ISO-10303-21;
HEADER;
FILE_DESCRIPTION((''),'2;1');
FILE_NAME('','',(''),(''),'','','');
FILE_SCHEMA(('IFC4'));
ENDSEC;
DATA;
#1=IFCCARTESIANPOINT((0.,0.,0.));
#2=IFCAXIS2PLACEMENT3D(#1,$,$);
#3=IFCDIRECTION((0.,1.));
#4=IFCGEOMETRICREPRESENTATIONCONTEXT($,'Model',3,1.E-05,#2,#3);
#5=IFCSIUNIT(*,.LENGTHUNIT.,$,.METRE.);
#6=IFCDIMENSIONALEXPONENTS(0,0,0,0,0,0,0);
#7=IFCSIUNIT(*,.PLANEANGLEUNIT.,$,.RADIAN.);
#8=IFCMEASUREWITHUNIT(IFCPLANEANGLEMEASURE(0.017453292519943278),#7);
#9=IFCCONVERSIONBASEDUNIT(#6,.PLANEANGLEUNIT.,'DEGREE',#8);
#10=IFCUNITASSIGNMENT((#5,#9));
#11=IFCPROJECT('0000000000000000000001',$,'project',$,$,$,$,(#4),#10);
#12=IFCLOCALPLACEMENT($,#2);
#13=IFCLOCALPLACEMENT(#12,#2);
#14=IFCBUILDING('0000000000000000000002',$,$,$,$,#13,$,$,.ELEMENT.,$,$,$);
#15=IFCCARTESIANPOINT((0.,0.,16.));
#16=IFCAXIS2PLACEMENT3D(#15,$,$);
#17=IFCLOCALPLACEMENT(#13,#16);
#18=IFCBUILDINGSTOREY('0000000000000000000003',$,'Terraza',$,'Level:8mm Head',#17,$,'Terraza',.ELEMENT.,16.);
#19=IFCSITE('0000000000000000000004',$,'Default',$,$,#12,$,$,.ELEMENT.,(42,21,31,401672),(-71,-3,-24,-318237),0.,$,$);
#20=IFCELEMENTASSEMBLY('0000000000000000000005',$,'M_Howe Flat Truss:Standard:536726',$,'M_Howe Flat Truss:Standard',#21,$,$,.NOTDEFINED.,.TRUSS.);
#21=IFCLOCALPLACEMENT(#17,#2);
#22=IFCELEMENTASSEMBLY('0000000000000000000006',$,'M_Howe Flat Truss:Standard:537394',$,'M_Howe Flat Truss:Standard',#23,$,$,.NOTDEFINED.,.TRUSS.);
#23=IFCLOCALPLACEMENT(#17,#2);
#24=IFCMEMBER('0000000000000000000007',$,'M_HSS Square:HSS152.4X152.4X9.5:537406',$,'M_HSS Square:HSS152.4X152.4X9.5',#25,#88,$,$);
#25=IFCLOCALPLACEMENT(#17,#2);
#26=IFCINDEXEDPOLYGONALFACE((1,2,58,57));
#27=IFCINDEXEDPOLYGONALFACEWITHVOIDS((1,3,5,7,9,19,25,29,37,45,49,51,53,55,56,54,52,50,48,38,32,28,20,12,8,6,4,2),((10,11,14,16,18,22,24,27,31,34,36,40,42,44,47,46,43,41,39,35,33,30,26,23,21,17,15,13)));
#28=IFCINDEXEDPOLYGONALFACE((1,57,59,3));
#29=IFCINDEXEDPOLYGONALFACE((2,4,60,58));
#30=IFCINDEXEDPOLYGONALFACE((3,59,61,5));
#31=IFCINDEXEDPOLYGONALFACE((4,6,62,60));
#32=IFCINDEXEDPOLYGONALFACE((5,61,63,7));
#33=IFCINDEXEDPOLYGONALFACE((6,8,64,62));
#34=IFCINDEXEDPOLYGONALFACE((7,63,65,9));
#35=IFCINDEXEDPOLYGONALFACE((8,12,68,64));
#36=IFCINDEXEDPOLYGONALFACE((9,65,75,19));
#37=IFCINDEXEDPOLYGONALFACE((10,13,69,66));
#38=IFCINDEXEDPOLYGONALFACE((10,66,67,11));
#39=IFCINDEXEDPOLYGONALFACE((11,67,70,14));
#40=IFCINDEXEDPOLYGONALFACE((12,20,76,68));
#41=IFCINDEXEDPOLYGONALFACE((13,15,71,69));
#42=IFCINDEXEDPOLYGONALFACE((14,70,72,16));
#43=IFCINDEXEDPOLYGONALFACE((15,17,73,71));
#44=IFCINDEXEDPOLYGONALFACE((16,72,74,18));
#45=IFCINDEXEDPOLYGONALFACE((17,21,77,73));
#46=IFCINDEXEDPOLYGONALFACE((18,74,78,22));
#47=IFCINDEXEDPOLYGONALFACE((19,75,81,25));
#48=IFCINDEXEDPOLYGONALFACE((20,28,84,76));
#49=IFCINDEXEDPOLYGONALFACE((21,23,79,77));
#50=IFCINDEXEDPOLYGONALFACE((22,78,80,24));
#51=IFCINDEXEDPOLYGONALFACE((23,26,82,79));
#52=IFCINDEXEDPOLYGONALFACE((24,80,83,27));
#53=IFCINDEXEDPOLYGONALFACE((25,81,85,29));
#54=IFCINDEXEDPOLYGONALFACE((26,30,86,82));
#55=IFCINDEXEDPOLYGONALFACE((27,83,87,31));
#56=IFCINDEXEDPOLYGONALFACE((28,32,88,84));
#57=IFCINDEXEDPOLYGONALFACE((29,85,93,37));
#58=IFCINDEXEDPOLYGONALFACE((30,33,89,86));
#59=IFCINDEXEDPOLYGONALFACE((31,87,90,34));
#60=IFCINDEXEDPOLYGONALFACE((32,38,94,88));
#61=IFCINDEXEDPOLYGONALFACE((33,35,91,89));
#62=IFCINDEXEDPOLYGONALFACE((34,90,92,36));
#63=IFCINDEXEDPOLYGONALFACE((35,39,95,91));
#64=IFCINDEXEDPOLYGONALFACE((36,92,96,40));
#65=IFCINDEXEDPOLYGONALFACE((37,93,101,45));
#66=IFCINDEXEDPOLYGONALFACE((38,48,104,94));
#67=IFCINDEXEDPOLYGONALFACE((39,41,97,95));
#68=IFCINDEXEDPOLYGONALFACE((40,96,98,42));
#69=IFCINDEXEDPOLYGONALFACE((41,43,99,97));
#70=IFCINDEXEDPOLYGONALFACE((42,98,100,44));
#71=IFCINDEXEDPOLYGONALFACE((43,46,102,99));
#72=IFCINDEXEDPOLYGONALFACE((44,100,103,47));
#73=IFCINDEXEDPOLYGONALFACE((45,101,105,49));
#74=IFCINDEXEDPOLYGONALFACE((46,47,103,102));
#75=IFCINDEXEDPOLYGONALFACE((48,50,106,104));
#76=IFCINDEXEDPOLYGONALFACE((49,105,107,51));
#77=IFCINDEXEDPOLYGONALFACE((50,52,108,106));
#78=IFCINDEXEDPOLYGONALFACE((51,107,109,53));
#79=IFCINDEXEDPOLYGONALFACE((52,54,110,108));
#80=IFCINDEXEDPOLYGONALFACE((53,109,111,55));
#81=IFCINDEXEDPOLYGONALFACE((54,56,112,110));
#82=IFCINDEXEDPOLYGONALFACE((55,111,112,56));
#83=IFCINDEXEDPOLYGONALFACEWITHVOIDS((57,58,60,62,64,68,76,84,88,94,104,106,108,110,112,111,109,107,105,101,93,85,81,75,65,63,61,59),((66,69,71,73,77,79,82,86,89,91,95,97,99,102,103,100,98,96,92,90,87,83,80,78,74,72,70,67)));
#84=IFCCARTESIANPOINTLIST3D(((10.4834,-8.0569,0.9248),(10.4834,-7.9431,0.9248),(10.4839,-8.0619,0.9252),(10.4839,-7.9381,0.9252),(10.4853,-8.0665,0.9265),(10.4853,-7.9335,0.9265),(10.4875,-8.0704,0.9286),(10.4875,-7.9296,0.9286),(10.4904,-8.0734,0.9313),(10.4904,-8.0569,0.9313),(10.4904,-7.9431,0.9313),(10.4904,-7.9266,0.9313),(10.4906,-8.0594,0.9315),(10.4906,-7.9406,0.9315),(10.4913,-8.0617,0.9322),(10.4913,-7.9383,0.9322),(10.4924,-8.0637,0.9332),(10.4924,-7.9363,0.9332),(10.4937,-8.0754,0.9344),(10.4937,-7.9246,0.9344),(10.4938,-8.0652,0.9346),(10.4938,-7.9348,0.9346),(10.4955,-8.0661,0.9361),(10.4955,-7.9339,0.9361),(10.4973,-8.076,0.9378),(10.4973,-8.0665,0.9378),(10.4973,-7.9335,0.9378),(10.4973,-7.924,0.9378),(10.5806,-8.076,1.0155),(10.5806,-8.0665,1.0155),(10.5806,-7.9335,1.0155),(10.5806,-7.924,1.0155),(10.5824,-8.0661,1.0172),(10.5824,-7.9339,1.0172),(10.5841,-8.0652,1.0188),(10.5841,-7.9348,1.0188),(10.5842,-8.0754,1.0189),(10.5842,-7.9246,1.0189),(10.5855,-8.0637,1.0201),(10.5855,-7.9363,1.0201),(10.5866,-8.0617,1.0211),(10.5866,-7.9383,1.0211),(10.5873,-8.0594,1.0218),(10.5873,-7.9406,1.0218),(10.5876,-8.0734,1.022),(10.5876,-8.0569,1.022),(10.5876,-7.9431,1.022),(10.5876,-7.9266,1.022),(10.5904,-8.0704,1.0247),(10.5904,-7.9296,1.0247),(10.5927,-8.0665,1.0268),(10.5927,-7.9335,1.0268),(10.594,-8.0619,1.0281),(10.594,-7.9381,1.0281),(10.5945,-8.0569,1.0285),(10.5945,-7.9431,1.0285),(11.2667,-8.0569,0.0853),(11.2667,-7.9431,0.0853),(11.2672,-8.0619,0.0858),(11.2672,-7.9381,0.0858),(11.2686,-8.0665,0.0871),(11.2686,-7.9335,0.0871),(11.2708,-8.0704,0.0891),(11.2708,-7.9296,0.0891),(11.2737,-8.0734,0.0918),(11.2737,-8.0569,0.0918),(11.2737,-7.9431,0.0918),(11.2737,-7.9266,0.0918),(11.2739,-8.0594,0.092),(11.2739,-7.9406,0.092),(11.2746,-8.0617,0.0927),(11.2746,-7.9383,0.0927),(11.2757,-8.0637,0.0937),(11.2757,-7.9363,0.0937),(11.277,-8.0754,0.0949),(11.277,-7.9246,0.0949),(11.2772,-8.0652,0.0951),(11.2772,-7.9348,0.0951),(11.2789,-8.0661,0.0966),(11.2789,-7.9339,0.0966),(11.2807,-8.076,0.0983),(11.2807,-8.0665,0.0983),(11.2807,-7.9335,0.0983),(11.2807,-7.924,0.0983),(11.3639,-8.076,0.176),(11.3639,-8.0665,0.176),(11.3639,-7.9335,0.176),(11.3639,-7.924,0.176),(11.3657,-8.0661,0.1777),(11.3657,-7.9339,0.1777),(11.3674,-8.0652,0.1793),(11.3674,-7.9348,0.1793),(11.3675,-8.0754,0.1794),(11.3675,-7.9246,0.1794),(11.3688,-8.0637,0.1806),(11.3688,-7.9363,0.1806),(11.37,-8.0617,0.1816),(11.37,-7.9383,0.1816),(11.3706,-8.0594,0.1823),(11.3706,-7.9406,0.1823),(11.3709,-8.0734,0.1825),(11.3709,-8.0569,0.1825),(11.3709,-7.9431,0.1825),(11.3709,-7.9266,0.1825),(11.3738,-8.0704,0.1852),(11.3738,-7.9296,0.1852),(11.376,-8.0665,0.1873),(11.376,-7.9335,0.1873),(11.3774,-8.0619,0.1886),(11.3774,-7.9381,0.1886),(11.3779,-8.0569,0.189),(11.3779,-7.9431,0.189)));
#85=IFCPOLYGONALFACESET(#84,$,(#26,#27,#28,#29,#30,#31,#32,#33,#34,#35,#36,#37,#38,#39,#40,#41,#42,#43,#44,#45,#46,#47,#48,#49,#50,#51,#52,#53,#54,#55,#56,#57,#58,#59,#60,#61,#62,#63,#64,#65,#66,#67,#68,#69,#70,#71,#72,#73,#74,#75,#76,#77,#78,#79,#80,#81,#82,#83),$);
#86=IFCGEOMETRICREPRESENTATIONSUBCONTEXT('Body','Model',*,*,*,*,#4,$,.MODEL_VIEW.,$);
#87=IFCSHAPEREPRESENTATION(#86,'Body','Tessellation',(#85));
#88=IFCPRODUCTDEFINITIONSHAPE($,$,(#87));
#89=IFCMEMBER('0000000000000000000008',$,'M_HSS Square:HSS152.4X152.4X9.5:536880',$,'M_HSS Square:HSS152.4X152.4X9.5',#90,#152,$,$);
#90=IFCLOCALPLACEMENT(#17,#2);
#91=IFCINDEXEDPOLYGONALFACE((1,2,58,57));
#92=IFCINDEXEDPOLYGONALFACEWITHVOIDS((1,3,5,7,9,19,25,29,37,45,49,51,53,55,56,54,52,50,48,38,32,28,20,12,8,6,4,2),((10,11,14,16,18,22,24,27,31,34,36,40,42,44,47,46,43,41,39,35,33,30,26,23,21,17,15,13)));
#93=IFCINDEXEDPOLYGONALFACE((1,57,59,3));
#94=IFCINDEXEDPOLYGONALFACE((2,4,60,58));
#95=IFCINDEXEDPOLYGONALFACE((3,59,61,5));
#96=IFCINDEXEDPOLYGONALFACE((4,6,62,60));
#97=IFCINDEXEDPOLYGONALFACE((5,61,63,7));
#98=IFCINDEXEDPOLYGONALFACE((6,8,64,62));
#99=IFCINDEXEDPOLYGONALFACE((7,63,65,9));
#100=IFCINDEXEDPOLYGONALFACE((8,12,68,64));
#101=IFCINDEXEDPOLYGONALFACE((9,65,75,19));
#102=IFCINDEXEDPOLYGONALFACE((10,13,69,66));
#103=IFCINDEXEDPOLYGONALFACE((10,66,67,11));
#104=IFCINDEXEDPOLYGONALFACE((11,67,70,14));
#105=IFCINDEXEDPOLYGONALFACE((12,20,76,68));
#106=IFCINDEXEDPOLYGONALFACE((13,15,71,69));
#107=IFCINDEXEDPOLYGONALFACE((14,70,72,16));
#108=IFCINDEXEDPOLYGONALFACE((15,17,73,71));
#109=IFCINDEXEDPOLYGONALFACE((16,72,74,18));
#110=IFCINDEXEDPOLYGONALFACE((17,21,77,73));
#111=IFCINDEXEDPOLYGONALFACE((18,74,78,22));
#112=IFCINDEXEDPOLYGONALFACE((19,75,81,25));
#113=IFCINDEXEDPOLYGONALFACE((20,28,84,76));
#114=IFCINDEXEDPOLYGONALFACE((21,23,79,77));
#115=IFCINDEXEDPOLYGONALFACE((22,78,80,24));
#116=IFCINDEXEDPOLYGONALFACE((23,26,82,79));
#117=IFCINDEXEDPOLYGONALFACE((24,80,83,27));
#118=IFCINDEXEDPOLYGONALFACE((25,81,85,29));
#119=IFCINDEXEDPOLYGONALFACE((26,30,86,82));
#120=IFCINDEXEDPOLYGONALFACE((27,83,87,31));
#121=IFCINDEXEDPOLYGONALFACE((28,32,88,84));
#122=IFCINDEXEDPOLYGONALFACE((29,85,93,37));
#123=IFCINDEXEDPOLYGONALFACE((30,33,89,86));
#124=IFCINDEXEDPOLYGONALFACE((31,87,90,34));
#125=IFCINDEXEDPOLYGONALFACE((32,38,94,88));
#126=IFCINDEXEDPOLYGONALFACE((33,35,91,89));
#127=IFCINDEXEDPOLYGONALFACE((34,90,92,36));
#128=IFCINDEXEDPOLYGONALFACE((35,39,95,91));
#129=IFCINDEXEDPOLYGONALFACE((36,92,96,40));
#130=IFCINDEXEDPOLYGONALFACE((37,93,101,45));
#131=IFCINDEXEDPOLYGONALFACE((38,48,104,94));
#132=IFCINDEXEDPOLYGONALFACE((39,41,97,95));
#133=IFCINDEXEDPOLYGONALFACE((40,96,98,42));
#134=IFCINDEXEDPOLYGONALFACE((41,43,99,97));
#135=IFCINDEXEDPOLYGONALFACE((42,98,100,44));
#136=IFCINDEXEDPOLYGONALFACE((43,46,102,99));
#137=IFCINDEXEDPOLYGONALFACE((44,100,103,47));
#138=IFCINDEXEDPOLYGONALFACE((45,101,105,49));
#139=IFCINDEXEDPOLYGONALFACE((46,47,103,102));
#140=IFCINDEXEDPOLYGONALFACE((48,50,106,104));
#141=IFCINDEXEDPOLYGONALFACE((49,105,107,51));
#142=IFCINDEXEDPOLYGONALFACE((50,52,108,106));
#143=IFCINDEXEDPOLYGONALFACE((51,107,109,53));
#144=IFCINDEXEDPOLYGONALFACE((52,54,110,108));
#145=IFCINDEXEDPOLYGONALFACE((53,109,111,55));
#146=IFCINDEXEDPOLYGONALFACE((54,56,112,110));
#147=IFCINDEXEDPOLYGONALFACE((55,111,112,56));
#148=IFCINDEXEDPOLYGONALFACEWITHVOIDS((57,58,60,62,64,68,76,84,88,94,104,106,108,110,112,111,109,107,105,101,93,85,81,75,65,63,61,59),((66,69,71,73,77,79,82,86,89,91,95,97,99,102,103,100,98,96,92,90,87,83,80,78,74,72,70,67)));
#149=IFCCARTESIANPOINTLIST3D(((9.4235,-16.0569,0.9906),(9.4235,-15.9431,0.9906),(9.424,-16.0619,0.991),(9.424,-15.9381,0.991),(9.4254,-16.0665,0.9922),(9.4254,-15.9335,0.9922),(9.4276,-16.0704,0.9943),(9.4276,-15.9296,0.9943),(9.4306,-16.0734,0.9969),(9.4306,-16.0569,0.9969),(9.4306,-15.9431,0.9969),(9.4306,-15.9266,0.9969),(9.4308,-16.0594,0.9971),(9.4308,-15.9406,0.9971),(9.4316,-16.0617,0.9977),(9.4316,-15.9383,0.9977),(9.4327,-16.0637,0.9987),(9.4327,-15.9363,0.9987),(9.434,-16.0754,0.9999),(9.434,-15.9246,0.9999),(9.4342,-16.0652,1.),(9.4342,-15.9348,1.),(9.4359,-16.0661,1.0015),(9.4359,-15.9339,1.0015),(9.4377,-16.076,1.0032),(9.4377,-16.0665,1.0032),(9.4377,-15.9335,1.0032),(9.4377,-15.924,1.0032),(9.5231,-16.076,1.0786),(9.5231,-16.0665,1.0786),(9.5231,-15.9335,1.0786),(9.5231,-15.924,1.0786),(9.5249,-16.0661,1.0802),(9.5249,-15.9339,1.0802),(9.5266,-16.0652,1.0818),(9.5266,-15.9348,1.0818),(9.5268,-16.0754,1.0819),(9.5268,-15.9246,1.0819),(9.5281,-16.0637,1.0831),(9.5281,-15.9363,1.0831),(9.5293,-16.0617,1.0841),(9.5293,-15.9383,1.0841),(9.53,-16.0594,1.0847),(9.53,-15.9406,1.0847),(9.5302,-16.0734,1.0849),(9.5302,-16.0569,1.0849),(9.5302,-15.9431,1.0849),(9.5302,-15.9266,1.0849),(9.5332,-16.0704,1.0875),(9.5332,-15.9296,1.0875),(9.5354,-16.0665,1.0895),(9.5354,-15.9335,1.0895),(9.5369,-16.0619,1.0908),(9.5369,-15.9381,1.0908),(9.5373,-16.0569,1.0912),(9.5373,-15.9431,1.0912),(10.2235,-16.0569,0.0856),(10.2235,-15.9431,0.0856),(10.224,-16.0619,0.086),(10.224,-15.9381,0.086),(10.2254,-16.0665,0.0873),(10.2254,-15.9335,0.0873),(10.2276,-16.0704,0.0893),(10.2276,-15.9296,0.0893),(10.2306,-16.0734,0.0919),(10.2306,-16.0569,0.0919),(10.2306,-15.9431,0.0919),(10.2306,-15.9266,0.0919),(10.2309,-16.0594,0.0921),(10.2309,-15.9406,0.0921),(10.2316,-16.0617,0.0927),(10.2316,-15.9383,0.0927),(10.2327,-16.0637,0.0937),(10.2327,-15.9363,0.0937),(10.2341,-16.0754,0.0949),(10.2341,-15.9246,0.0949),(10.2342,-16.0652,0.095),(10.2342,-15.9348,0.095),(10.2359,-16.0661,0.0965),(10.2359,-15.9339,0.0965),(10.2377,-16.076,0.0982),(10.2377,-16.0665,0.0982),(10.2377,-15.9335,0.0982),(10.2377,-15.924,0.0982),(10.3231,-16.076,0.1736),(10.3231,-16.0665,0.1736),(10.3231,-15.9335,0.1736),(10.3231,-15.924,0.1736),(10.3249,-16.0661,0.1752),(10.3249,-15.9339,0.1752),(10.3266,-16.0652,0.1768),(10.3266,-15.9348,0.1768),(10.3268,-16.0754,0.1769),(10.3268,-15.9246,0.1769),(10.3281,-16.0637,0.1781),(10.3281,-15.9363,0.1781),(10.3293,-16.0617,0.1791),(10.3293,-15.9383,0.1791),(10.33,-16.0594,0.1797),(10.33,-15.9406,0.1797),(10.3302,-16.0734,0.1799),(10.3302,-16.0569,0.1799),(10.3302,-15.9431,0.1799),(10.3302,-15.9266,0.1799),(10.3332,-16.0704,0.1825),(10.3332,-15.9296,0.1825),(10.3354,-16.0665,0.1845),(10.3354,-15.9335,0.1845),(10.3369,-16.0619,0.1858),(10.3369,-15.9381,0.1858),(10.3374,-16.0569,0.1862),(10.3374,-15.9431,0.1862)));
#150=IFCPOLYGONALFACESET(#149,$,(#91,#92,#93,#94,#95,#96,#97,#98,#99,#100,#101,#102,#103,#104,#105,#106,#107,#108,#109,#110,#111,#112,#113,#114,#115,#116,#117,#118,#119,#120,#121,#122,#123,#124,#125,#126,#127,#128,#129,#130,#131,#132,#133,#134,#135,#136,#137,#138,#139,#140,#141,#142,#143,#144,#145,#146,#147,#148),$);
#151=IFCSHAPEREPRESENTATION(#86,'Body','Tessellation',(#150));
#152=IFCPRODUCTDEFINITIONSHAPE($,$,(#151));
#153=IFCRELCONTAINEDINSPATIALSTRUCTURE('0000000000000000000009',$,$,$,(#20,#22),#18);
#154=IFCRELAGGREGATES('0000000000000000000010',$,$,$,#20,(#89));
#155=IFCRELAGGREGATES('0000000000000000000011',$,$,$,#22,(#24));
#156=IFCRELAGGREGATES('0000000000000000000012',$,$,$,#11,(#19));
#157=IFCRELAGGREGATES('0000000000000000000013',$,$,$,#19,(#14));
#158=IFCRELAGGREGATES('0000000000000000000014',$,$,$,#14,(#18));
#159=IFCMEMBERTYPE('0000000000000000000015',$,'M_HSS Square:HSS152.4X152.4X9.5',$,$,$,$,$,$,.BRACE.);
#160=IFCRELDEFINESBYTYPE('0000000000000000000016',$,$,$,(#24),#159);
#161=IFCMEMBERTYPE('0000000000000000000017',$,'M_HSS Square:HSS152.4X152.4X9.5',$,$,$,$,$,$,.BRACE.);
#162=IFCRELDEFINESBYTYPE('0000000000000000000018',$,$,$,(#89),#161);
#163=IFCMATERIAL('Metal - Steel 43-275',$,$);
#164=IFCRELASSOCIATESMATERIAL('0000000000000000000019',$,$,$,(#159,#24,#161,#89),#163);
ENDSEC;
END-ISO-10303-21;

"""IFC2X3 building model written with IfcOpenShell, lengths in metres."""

from ifc_helpers import new_model, entity, si_unit, converted_unit, direction, frame, frame_2d, origin, place, context, subcontext, project, spatial, polyline, circle_curve, parameter, trimmed, segment, composite_curve, outline, extrude, source, transform, mapped, material, type_object, type_shapes, element, aggregate, save


model = new_model("IFC2X3")

# Units and contexts
model_context = context("Model", 3, precision=1e-05, world=origin(), true_north=direction((0.0, 1.0)))
body_context = subcontext(model_context, "Body", "Model", "MODEL_VIEW")
ifc_project = project(units=[si_unit("LENGTHUNIT", "METRE"), converted_unit("PLANEANGLEUNIT", "DEGREE", entity("IfcPlaneAngleMeasure", 0.017453292519943278), si_unit("PLANEANGLEUNIT", "RADIAN"), dimensions=[0, 0, 0, 0, 0, 0, 0])], contexts=[model_context])

# Site, building, storey
site_placement = place(None, origin())
site = spatial("IfcSite", under=ifc_project, at=site_placement, Name="Default", CompositionType="ELEMENT", RefLatitude=(42, 21, 31, 401672), RefLongitude=(-71, -3, -24, -318237), RefElevation=0.0)
building_placement = place(site_placement, origin())
building = spatial("IfcBuilding", under=site, at=building_placement, CompositionType="ELEMENT")
storey_placement = place(building_placement, frame((0.0, 0.0, 16.0)))
storey = spatial("IfcBuildingStorey", under=building, at=storey_placement, Name="Terraza", ObjectType="Level:8mm Head", LongName="Terraza", CompositionType="ELEMENT", Elevation=16.0)

# Element assemblies
assembly_1_placement = place(storey_placement, origin())
assembly_1 = element("IfcElementAssembly", 1, at=assembly_1_placement, inside=storey, Name="M_Howe Flat Truss:Standard:536726", ObjectType="M_Howe Flat Truss:Standard", AssemblyPlace="NOTDEFINED", PredefinedType="TRUSS")
ifc_material = material(Name="Metal - Steel 43-275")
assembly_2_placement = place(storey_placement, origin())
assembly_2 = element("IfcElementAssembly", 2, at=assembly_2_placement, inside=storey, Name="M_Howe Flat Truss:Standard:537394", ObjectType="M_Howe Flat Truss:Standard", AssemblyPlace="NOTDEFINED", PredefinedType="TRUSS")

# Members
member_type_1 = type_object("IfcMemberType", Name="M_HSS Square:HSS152.4X152.4X9.5", PredefinedType="BRACE", material=ifc_material)
shared_shape_1 = source(origin(), body_context, "Body", "SweptSolid", [
    extrude(outline(composite_curve([segment(polyline([(-0.0569, -0.076), (0.0569, -0.076)]), True, "CONTINUOUS"), segment(trimmed(circle_curve(frame_2d((0.0569, -0.0569), x_axis=(0.0, 1.0)), 0.0191), [parameter(180.0)], [parameter(270.0)], True, "PARAMETER"), True, "CONTINUOUS"), segment(polyline([(0.076, -0.0569), (0.076, 0.0569)]), True, "CONTINUOUS"), segment(trimmed(circle_curve(frame_2d((0.0569, 0.0569), x_axis=(0.0, 1.0)), 0.0191), [parameter(270.0)], [parameter(0.0)], True, "PARAMETER"), True, "CONTINUOUS"), segment(polyline([(0.0569, 0.076), (-0.0569, 0.076)]), True, "CONTINUOUS"), segment(trimmed(circle_curve(frame_2d((-0.0569, 0.0569), x_axis=(0.0, 1.0)), 0.0191), [parameter(0.0)], [parameter(90.0)], True, "PARAMETER"), True, "CONTINUOUS"), segment(polyline([(-0.076, 0.0569), (-0.076, -0.0569)]), True, "CONTINUOUS"), segment(trimmed(circle_curve(frame_2d((-0.0569, -0.0569), x_axis=(0.0, 1.0)), 0.0191), [parameter(90.0)], [parameter(180.0)], True, "PARAMETER"), True, "CONTINUOUS")], self_intersect=False), holes=[composite_curve([segment(trimmed(circle_curve(frame_2d((-0.0569, 0.0569), x_axis=(0.0, 1.0)), 0.0095), [parameter(360.0)], [parameter(90.0)], True, "PARAMETER"), False, "CONTINUOUS"), segment(polyline([(-0.0569, 0.0665), (0.0569, 0.0665)]), True, "CONTINUOUS"), segment(trimmed(circle_curve(frame_2d((0.0569, 0.0569), x_axis=(0.0, 1.0)), 0.0095), [parameter(270.0)], [parameter(360.0)], True, "PARAMETER"), False, "CONTINUOUS"), segment(polyline([(0.0665, 0.0569), (0.0665, -0.0569)]), True, "CONTINUOUS"), segment(trimmed(circle_curve(frame_2d((0.0569, -0.0569), x_axis=(0.0, 1.0)), 0.0095), [parameter(180.0)], [parameter(270.0)], True, "PARAMETER"), False, "CONTINUOUS"), segment(polyline([(0.0569, -0.0665), (-0.0569, -0.0665)]), True, "CONTINUOUS"), segment(trimmed(circle_curve(frame_2d((-0.0569, -0.0569), x_axis=(0.0, 1.0)), 0.0095), [parameter(90.0)], [parameter(180.0)], True, "PARAMETER"), False, "CONTINUOUS"), segment(polyline([(-0.0665, -0.0569), (-0.0665, 0.0569)]), True, "CONTINUOUS")], self_intersect=False)]), frame((-0.5665, 0.0, 0.0), z_axis=(1.0, 0.0, 0.0), x_axis=(0.0, 0.0, -1.0)), (0.0, 0.0, 1.0), 1.1482),
])
type_shapes(member_type_1, [shared_shape_1])
member_1_placement = place(assembly_2_placement, frame((10.9254, -8.0, 0.5625), z_axis=(-0.731142, 0.0, -0.682225), x_axis=(0.682225, 0.0, -0.731142)))
member_1 = element("IfcMember", 3, at=member_1_placement, type_object=member_type_1, material=ifc_material, Name="M_HSS Square:HSS152.4X152.4X9.5:537406", ObjectType="M_HSS Square:HSS152.4X152.4X9.5", context=body_context, shape_type="MappedRepresentation", body=[
    mapped(shared_shape_1, transform((0.0, 0.0, 0.0), scale=1.0)),
])
member_type_2 = type_object("IfcMemberType", Name="M_HSS Square:HSS152.4X152.4X9.5", PredefinedType="BRACE", material=ifc_material)
shared_shape_2 = source(origin(), body_context, "Body", "SweptSolid", [
    extrude(outline(composite_curve([segment(polyline([(-0.0569, -0.076), (0.0569, -0.076)]), True, "CONTINUOUS"), segment(trimmed(circle_curve(frame_2d((0.0569, -0.0569), x_axis=(0.0, 1.0)), 0.0191), [parameter(180.0)], [parameter(270.0)], True, "PARAMETER"), True, "CONTINUOUS"), segment(polyline([(0.076, -0.0569), (0.076, 0.0569)]), True, "CONTINUOUS"), segment(trimmed(circle_curve(frame_2d((0.0569, 0.0569), x_axis=(0.0, 1.0)), 0.0191), [parameter(270.0)], [parameter(0.0)], True, "PARAMETER"), True, "CONTINUOUS"), segment(polyline([(0.0569, 0.076), (-0.0569, 0.076)]), True, "CONTINUOUS"), segment(trimmed(circle_curve(frame_2d((-0.0569, 0.0569), x_axis=(0.0, 1.0)), 0.0191), [parameter(0.0)], [parameter(90.0)], True, "PARAMETER"), True, "CONTINUOUS"), segment(polyline([(-0.076, 0.0569), (-0.076, -0.0569)]), True, "CONTINUOUS"), segment(trimmed(circle_curve(frame_2d((-0.0569, -0.0569), x_axis=(0.0, 1.0)), 0.0191), [parameter(90.0)], [parameter(180.0)], True, "PARAMETER"), True, "CONTINUOUS")], self_intersect=False), holes=[composite_curve([segment(trimmed(circle_curve(frame_2d((-0.0569, 0.0569), x_axis=(0.0, 1.0)), 0.0095), [parameter(360.0)], [parameter(90.0)], True, "PARAMETER"), False, "CONTINUOUS"), segment(polyline([(-0.0569, 0.0665), (0.0569, 0.0665)]), True, "CONTINUOUS"), segment(trimmed(circle_curve(frame_2d((0.0569, 0.0569), x_axis=(0.0, 1.0)), 0.0095), [parameter(270.0)], [parameter(360.0)], True, "PARAMETER"), False, "CONTINUOUS"), segment(polyline([(0.0665, 0.0569), (0.0665, -0.0569)]), True, "CONTINUOUS"), segment(trimmed(circle_curve(frame_2d((0.0569, -0.0569), x_axis=(0.0, 1.0)), 0.0095), [parameter(180.0)], [parameter(270.0)], True, "PARAMETER"), False, "CONTINUOUS"), segment(polyline([(0.0569, -0.0665), (-0.0569, -0.0665)]), True, "CONTINUOUS"), segment(trimmed(circle_curve(frame_2d((-0.0569, -0.0569), x_axis=(0.0, 1.0)), 0.0095), [parameter(90.0)], [parameter(180.0)], True, "PARAMETER"), False, "CONTINUOUS"), segment(polyline([(-0.0665, -0.0569), (-0.0665, 0.0569)]), True, "CONTINUOUS")], self_intersect=False)]), frame((-0.5968, 0.0, 0.0), z_axis=(1.0, 0.0, 0.0), x_axis=(0.0, 0.0, -1.0)), (0.0, 0.0, 1.0), 1.2079),
])
type_shapes(member_type_2, [shared_shape_2])
member_2_placement = place(assembly_1_placement, frame((9.8757, -16.0, 0.5937), z_axis=(-0.749231, 0.0, -0.662309), x_axis=(0.662309, 0.0, -0.749231)))
member_2 = element("IfcMember", 4, at=member_2_placement, type_object=member_type_2, material=ifc_material, Name="M_HSS Square:HSS152.4X152.4X9.5:536880", ObjectType="M_HSS Square:HSS152.4X152.4X9.5", context=body_context, shape_type="MappedRepresentation", body=[
    mapped(shared_shape_2, transform((0.0, 0.0, 0.0), scale=1.0)),
])
aggregate(assembly_1, [member_2])
aggregate(assembly_2, [member_1])

save(model, "model.ifc")
